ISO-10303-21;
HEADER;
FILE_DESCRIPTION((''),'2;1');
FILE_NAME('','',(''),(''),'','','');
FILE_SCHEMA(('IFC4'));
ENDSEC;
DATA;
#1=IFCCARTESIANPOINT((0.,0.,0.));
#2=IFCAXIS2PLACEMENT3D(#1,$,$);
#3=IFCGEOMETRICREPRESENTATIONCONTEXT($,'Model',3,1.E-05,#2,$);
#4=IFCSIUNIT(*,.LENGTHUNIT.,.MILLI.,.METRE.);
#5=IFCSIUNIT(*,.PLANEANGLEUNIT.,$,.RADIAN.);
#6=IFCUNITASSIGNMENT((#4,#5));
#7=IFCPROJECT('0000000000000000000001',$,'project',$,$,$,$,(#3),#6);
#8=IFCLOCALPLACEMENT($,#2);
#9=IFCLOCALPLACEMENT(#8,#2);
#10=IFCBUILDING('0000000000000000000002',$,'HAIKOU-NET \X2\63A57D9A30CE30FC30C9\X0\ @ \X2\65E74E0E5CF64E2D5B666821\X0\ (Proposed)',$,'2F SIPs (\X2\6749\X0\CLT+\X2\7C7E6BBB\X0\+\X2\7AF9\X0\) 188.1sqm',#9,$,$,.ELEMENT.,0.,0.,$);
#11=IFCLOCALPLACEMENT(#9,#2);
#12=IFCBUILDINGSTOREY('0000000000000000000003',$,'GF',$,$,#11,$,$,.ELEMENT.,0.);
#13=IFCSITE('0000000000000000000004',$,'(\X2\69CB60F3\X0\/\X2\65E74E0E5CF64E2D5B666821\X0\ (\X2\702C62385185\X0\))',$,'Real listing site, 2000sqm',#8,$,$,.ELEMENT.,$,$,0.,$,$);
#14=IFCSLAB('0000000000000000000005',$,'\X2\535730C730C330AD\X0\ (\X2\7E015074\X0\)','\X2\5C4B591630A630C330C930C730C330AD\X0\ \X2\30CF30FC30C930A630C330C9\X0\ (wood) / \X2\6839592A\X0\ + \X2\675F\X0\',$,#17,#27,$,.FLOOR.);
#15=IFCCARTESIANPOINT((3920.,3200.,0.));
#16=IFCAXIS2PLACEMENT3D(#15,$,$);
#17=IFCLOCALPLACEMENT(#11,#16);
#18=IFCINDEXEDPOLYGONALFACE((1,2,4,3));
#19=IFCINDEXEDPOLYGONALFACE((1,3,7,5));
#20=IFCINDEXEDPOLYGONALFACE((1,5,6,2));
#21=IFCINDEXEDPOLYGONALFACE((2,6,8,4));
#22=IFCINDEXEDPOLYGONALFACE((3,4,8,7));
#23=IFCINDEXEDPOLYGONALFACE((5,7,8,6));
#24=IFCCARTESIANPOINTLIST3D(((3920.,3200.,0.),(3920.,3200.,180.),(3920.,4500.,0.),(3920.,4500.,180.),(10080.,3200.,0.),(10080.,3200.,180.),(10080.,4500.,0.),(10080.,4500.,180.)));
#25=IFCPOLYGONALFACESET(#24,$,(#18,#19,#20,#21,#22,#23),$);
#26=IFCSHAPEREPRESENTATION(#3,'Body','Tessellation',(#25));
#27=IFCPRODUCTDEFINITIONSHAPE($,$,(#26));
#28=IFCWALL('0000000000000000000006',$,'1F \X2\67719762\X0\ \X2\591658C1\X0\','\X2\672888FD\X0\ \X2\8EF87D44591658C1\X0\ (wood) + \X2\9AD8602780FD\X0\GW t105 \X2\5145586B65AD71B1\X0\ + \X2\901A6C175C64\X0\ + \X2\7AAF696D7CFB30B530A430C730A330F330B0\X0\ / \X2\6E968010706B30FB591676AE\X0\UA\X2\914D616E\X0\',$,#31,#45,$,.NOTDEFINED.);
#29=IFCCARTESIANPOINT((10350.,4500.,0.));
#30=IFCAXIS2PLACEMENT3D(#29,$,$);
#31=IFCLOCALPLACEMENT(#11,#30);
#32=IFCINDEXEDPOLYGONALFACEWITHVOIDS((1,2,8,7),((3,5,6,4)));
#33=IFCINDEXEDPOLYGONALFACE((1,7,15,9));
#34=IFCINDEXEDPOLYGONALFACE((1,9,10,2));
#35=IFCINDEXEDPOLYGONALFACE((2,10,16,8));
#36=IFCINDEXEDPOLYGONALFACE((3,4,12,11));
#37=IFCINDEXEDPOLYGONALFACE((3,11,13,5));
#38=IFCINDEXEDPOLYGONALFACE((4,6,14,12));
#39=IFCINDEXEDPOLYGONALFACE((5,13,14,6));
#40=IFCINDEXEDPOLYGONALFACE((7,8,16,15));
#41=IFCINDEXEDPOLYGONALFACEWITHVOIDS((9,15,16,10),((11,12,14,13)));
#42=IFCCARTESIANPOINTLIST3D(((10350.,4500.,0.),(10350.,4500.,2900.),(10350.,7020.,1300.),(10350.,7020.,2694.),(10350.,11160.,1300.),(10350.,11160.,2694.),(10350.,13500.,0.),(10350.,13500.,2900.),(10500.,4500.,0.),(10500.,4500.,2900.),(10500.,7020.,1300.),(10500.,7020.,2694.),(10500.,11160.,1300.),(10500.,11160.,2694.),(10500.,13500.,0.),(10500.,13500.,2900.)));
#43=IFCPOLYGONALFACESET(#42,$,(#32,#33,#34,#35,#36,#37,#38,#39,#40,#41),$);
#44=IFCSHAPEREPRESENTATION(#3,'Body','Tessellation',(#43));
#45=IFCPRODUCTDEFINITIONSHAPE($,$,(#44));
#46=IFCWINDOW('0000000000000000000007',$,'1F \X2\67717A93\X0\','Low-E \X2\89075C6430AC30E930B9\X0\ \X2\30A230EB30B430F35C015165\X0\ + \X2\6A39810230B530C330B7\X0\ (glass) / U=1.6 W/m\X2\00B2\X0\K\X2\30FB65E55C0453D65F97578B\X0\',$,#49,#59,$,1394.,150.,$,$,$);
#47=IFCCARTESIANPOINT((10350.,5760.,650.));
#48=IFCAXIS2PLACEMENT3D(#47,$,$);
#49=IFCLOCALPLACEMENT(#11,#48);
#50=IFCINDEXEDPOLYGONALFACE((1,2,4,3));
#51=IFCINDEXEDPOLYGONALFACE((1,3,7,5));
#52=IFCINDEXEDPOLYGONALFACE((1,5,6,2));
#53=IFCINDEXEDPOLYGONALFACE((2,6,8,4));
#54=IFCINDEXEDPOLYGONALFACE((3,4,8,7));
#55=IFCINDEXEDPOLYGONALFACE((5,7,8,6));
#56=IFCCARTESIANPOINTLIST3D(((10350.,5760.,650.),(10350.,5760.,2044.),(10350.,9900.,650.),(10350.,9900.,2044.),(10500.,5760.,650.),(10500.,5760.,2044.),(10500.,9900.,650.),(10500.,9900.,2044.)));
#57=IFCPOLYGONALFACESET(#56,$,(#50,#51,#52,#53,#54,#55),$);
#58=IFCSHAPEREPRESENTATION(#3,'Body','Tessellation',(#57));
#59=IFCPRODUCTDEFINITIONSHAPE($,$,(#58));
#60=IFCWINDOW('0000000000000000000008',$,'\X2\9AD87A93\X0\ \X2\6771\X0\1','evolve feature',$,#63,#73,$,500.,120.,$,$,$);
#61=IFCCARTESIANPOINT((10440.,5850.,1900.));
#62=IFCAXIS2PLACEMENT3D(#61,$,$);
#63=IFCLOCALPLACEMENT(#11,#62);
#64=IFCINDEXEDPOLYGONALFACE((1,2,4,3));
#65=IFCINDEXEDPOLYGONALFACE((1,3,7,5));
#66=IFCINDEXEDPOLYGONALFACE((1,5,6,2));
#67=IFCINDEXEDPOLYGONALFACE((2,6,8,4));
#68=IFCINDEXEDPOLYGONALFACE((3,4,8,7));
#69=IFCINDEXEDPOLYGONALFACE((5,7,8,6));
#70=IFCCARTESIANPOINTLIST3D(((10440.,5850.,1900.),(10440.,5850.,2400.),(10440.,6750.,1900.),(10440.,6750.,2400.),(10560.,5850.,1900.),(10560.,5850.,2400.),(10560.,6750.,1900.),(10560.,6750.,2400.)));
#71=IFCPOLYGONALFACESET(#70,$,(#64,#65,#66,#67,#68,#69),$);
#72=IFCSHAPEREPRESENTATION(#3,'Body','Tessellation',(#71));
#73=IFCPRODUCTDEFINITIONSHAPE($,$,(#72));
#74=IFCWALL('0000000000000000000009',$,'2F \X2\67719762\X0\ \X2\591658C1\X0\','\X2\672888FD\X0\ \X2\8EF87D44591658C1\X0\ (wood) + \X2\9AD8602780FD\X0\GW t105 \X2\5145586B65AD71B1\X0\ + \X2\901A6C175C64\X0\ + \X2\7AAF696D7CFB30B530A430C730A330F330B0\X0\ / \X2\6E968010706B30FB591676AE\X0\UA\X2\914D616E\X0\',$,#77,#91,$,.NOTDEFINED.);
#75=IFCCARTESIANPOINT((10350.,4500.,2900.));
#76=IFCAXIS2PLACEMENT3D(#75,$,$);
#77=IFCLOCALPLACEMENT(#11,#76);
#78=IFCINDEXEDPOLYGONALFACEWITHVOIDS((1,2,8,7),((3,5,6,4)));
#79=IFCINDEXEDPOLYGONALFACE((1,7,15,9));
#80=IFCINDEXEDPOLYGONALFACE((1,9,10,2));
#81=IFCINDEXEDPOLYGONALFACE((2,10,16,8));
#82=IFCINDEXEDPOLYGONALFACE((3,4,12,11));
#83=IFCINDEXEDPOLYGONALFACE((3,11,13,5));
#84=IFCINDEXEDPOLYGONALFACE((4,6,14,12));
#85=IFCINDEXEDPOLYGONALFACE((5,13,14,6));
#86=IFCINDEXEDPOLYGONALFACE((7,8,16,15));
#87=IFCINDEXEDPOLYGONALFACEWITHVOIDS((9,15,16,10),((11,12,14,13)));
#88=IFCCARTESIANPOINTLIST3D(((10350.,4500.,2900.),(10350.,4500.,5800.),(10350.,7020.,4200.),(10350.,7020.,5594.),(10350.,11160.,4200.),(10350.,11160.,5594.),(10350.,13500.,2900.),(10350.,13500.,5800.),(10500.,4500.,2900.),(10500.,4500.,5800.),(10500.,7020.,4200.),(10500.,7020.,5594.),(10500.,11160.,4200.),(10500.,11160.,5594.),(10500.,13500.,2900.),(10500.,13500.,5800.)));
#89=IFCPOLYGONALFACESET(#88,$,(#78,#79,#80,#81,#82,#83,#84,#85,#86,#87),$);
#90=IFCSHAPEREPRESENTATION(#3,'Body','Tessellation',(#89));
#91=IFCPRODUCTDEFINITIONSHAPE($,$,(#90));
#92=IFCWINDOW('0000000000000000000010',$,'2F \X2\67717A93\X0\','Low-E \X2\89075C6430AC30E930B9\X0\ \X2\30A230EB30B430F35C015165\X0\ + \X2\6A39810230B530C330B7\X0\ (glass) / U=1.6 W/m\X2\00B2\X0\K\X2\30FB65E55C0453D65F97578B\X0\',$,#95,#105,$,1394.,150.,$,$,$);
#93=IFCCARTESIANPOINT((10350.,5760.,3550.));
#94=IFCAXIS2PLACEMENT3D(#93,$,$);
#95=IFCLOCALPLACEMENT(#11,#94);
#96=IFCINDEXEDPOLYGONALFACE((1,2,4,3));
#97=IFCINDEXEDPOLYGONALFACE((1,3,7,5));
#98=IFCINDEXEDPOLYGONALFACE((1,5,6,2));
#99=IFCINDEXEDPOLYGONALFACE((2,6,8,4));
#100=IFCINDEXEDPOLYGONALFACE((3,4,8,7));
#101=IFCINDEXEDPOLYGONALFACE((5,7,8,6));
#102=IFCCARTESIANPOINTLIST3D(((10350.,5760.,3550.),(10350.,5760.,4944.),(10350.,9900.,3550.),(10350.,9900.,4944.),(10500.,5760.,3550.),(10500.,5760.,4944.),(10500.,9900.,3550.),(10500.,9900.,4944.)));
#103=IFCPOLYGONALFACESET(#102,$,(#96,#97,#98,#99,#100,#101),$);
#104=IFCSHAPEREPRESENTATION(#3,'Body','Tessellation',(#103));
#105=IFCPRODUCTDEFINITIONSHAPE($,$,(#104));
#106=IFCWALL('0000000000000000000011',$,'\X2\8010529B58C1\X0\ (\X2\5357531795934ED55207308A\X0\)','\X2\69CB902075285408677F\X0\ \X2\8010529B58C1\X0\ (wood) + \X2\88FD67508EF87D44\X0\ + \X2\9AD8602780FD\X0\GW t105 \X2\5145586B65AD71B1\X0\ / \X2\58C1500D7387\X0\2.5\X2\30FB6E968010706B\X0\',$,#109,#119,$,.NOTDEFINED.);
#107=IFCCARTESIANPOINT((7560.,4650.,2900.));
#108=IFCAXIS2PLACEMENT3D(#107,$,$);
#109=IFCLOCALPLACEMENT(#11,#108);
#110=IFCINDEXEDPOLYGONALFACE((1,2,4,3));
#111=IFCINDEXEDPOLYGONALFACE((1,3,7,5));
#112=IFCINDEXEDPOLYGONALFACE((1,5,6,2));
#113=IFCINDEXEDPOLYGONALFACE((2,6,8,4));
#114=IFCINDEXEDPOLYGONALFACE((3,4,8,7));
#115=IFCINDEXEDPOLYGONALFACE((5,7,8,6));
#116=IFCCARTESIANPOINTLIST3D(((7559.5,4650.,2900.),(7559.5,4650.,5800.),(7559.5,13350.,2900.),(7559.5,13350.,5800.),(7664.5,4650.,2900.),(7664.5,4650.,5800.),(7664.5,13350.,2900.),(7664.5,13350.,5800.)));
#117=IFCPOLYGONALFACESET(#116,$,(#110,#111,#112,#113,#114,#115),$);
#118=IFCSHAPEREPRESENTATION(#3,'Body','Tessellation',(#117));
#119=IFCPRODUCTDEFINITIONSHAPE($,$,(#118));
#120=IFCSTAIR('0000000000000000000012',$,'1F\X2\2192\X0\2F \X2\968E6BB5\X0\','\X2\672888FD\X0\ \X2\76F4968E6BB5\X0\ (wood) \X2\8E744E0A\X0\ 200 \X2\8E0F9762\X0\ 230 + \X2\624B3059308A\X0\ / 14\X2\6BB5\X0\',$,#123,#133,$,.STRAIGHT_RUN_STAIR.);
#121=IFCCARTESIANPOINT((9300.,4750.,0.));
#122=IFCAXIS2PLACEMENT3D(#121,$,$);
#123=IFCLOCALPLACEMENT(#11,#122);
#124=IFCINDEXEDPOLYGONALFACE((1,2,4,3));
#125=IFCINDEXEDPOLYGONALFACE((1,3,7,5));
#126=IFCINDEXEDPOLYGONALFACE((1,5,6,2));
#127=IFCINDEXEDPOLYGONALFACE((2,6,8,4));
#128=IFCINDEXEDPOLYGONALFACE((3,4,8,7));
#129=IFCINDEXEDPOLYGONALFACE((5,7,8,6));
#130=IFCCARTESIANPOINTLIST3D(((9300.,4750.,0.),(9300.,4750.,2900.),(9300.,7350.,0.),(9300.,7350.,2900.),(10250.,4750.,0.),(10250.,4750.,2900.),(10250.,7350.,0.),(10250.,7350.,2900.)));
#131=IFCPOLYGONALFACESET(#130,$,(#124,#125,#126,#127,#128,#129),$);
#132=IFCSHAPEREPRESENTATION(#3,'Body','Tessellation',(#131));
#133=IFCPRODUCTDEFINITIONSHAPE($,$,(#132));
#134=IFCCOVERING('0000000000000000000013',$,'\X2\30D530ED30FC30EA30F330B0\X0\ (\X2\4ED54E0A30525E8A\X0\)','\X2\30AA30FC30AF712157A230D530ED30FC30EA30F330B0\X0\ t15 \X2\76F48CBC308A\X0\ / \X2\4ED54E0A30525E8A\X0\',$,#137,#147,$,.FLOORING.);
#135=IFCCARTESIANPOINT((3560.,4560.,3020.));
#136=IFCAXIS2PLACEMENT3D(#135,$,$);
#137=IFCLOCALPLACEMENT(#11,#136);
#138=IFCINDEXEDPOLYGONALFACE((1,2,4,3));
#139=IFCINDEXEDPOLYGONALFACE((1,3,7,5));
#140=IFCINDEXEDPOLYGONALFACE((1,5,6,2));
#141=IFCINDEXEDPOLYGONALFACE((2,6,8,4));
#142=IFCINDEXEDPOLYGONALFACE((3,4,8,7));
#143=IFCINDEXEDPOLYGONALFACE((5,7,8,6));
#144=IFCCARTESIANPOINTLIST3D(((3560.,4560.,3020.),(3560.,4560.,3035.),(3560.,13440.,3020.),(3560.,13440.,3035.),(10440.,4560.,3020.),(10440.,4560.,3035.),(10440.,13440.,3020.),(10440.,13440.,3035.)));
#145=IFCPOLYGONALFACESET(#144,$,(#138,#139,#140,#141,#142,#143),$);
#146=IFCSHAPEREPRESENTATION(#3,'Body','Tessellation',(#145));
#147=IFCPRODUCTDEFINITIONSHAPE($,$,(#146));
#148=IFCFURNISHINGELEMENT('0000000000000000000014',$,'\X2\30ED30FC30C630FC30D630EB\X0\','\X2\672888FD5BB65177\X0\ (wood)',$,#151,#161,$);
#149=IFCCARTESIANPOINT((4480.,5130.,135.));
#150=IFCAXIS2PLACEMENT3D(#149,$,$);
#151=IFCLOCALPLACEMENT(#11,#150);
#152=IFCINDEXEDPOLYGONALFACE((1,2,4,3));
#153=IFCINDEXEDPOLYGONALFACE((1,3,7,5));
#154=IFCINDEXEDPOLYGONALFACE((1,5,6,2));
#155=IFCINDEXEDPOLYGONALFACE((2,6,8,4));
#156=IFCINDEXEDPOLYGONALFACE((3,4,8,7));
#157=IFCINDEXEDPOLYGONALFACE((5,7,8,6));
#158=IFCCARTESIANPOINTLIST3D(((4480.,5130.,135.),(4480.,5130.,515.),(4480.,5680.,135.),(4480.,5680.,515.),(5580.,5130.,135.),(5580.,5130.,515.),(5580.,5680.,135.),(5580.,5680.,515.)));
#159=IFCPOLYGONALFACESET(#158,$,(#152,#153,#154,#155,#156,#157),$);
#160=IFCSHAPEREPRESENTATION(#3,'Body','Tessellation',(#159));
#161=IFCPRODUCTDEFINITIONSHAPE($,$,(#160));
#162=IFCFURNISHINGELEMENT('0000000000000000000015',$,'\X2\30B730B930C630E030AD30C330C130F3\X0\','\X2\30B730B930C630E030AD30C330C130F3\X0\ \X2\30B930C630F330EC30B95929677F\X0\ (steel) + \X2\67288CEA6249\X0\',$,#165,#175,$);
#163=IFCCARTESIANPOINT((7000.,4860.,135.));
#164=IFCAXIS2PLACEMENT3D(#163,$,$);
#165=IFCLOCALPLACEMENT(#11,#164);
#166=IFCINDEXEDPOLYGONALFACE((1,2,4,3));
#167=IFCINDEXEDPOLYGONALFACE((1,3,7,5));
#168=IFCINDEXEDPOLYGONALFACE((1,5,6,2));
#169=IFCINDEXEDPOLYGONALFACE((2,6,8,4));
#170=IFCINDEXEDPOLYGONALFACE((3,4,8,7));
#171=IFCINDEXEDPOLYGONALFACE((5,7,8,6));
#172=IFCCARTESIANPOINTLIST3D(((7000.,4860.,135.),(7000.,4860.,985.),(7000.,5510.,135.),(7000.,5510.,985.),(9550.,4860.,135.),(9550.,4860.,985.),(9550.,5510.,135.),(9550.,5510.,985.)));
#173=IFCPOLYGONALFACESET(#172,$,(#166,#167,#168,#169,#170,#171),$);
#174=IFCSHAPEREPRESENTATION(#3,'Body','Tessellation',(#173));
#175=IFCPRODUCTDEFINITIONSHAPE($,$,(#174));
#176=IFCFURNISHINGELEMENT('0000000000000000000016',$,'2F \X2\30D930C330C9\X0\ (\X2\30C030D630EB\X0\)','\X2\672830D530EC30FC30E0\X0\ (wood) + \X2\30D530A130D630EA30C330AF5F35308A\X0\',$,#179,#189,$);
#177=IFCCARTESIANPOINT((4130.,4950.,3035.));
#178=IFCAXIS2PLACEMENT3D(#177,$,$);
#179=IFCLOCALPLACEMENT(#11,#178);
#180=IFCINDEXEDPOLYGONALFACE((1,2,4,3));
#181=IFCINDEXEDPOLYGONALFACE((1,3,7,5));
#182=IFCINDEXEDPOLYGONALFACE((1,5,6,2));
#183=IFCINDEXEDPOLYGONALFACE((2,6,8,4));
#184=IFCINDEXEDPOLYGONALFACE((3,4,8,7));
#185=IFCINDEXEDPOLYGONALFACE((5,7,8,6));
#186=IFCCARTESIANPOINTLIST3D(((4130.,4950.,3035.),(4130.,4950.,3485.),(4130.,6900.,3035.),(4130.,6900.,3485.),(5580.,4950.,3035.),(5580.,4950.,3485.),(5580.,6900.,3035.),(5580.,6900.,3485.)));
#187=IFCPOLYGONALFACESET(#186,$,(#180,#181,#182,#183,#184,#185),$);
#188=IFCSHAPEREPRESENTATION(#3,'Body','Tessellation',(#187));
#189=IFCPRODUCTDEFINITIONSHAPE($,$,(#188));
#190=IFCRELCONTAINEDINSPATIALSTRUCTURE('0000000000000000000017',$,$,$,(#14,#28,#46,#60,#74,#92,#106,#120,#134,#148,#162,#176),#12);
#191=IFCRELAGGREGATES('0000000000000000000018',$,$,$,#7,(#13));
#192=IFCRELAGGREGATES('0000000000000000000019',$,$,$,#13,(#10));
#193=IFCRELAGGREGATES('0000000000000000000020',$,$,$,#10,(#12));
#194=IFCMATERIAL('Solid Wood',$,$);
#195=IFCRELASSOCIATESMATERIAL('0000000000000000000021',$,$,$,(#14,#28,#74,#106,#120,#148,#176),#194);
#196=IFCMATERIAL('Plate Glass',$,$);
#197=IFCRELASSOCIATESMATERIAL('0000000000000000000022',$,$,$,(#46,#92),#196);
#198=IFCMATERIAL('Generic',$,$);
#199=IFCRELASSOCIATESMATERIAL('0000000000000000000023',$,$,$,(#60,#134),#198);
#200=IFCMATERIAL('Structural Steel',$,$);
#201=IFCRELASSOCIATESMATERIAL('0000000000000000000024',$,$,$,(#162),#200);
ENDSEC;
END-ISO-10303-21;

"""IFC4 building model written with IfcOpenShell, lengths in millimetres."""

from ifc_helpers import new_model, si_unit, frame, frame_2d, origin, place, context, project, spatial, rectangle, extrude, material, element, fill, save


model = new_model("IFC4")

# Units and contexts
model_context = context("Model", 3, precision=1e-05, world=origin())
ifc_project = project(units=[si_unit("LENGTHUNIT", "METRE", prefix="MILLI"), si_unit("PLANEANGLEUNIT", "RADIAN")], contexts=[model_context])

# Site, building, storey
site_placement = place(None, origin())
site = spatial("IfcSite", under=ifc_project, at=site_placement, Name="(構想/旧与島中学校 (瀬戸内))", ObjectType="Real listing site, 2000sqm", CompositionType="ELEMENT", RefElevation=0.0)
building_placement = place(site_placement, origin())
building = spatial("IfcBuilding", under=site, at=building_placement, Name="HAIKOU-NET 接続ノード @ 旧与島中学校 (Proposed)", ObjectType="2F SIPs (杉CLT+籾殻+竹) 188.1sqm", CompositionType="ELEMENT", ElevationOfRefHeight=0.0, ElevationOfTerrain=0.0)
storey_placement = place(building_placement, origin())
storey = spatial("IfcBuildingStorey", under=building, at=storey_placement, Name="GF", CompositionType="ELEMENT", Elevation=0.0)

# Slab
ifc_material_1 = material(Name="Solid Wood")
slab_placement = place(storey_placement, frame((3920.0, 3200.0, 0.0)))
element("IfcSlab", 1, at=slab_placement, inside=storey, material=ifc_material_1, Name="南デッキ (縁側)", Description="屋外ウッドデッキ ハードウッド (wood) / 根太 + 束", PredefinedType="FLOOR", context=model_context, shape_type="SweptSolid", body=[
    extrude(rectangle(XDim=6160.0, YDim=1300.0, at=frame_2d((3080.0, 650.0))), frame((3920.0, 3200.0, 0.0)), (0.0, 0.0, 1.0), 180.0),
])

# Wall, openings, windows
wall_1_placement = place(storey_placement, frame((10350.0, 4500.0, 0.0)))
wall_1 = element("IfcWall", 2, at=wall_1_placement, inside=storey, material=ifc_material_1, Name="1F 東面 外壁", Description="木製 軸組外壁 (wood) + 高性能GW t105 充填断熱 + 通気層 + 窯業系サイディング / 準耐火・外皮UA配慮", PredefinedType="NOTDEFINED", context=model_context, shape_type="SweptSolid", body=[
    extrude(rectangle(XDim=150.0, YDim=9000.0, at=frame_2d((75.0, 4500.0))), frame((10350.0, 4500.0, 0.0)), (0.0, 0.0, 1.0), 2900.0),
])
opening_1_placement = place(storey_placement, frame((10350.0, 5760.0, 650.0)))
opening_1 = element("IfcOpeningElement", 3, at=opening_1_placement, cuts=wall_1, PredefinedType="NOTDEFINED", context=model_context, shape_type="SweptSolid", body=[
    extrude(rectangle(XDim=150.0, YDim=4140.0, at=frame_2d((75.0, 2070.0))), frame((10350.0, 5760.0, 650.0)), (0.0, 0.0, 1.0), 1394.0),
])
opening_2_placement = place(storey_placement, frame((10440.0, 5850.0, 1900.0)))
opening_2 = element("IfcOpeningElement", 4, at=opening_2_placement, cuts=wall_1, PredefinedType="NOTDEFINED", context=model_context, shape_type="SweptSolid", body=[
    extrude(rectangle(XDim=120.0, YDim=900.0, at=frame_2d((60.0, 450.0))), frame((10440.0, 5850.0, 1900.0)), (0.0, 0.0, 1.0), 500.0),
])
ifc_material_2 = material(Name="Plate Glass")
window_1_placement = place(storey_placement, frame((10350.0, 5760.0, 650.0)))
window_1 = element("IfcWindow", 5, at=window_1_placement, inside=storey, material=ifc_material_2, Name="1F 東窓", Description="Low-E 複層ガラス アルゴン封入 + 樹脂サッシ (glass) / U=1.6 W/m²K・日射取得型", OverallHeight=1394.0, OverallWidth=150.0, context=model_context, shape_type="SweptSolid", body=[
    extrude(rectangle(XDim=150.0, YDim=4140.0, at=frame_2d((75.0, 2070.0))), frame((10350.0, 5760.0, 650.0)), (0.0, 0.0, 1.0), 1394.0),
])
fill(opening_1, window_1)
ifc_material_3 = material(Name="Generic")
window_2_placement = place(storey_placement, frame((10440.0, 5850.0, 1900.0)))
window_2 = element("IfcWindow", 6, at=window_2_placement, inside=storey, material=ifc_material_3, Name="高窓 東1", Description="evolve feature", OverallHeight=500.0, OverallWidth=120.0, context=model_context, shape_type="SweptSolid", body=[
    extrude(rectangle(XDim=120.0, YDim=900.0, at=frame_2d((60.0, 450.0))), frame((10440.0, 5850.0, 1900.0)), (0.0, 0.0, 1.0), 500.0),
])
fill(opening_2, window_2)

# Wall, opening, window
wall_2_placement = place(storey_placement, frame((10350.0, 4500.0, 2900.0)))
wall_2 = element("IfcWall", 7, at=wall_2_placement, inside=storey, material=ifc_material_1, Name="2F 東面 外壁", Description="木製 軸組外壁 (wood) + 高性能GW t105 充填断熱 + 通気層 + 窯業系サイディング / 準耐火・外皮UA配慮", PredefinedType="NOTDEFINED", context=model_context, shape_type="SweptSolid", body=[
    extrude(rectangle(XDim=150.0, YDim=9000.0, at=frame_2d((75.0, 4500.0))), frame((10350.0, 4500.0, 2900.0)), (0.0, 0.0, 1.0), 2900.0),
])
opening_3_placement = place(storey_placement, frame((10350.0, 5760.0, 3550.0)))
opening_3 = element("IfcOpeningElement", 8, at=opening_3_placement, cuts=wall_2, PredefinedType="NOTDEFINED", context=model_context, shape_type="SweptSolid", body=[
    extrude(rectangle(XDim=150.0, YDim=4140.0, at=frame_2d((75.0, 2070.0))), frame((10350.0, 5760.0, 3550.0)), (0.0, 0.0, 1.0), 1394.0),
])
window_3_placement = place(storey_placement, frame((10350.0, 5760.0, 3550.0)))
window_3 = element("IfcWindow", 9, at=window_3_placement, inside=storey, material=ifc_material_2, Name="2F 東窓", Description="Low-E 複層ガラス アルゴン封入 + 樹脂サッシ (glass) / U=1.6 W/m²K・日射取得型", OverallHeight=1394.0, OverallWidth=150.0, context=model_context, shape_type="SweptSolid", body=[
    extrude(rectangle(XDim=150.0, YDim=4140.0, at=frame_2d((75.0, 2070.0))), frame((10350.0, 5760.0, 3550.0)), (0.0, 0.0, 1.0), 1394.0),
])
fill(opening_3, window_3)

# Wall
wall_3_placement = place(storey_placement, frame((7560.0, 4650.0, 2900.0)))
element("IfcWall", 10, at=wall_3_placement, inside=storey, material=ifc_material_1, Name="耐力壁 (南北間仕切り)", Description="構造用合板 耐力壁 (wood) + 製材軸組 + 高性能GW t105 充填断熱 / 壁倍率2.5・準耐火", PredefinedType="NOTDEFINED", context=model_context, shape_type="SweptSolid", body=[
    extrude(rectangle(XDim=105.0, YDim=8700.0, at=frame_2d((52.0, 4350.0))), frame((7560.0, 4650.0, 2900.0)), (0.0, 0.0, 1.0), 2900.0),
])

# Stair
stair_placement = place(storey_placement, frame((9300.0, 4750.0, 0.0)))
element("IfcStair", 11, at=stair_placement, inside=storey, material=ifc_material_1, Name="1F→2F 階段", Description="木製 直階段 (wood) 蹴上 200 踏面 230 + 手すり / 14段", PredefinedType="STRAIGHT_RUN_STAIR", context=model_context, shape_type="SweptSolid", body=[
    extrude(rectangle(XDim=950.0, YDim=2600.0, at=frame_2d((475.0, 1300.0))), frame((9300.0, 4750.0, 0.0)), (0.0, 0.0, 1.0), 2900.0),
])

# Covering
covering_placement = place(storey_placement, frame((3560.0, 4560.0, 3020.0)))
element("IfcCovering", 12, at=covering_placement, inside=storey, material=ifc_material_3, Name="フローリング (仕上げ床)", Description="オーク無垢フローリング t15 直貼り / 仕上げ床", PredefinedType="FLOORING", context=model_context, shape_type="SweptSolid", body=[
    extrude(rectangle(XDim=6880.0, YDim=8880.0, at=frame_2d((3440.0, 4440.0))), frame((3560.0, 4560.0, 3020.0)), (0.0, 0.0, 1.0), 15.0),
])

# Furnishing elements
furnishing_1_placement = place(storey_placement, frame((4480.0, 5130.0, 135.0)))
element("IfcFurnishingElement", 13, at=furnishing_1_placement, inside=storey, material=ifc_material_1, Name="ローテーブル", Description="木製家具 (wood)", context=model_context, shape_type="SweptSolid", body=[
    extrude(rectangle(XDim=1100.0, YDim=550.0, at=frame_2d((550.0, 275.0))), frame((4480.0, 5130.0, 135.0)), (0.0, 0.0, 1.0), 380.0),
])
ifc_material_4 = material(Name="Structural Steel")
furnishing_2_placement = place(storey_placement, frame((7000.0, 4860.0, 135.0)))
element("IfcFurnishingElement", 14, at=furnishing_2_placement, inside=storey, material=ifc_material_4, Name="システムキッチン", Description="システムキッチン ステンレス天板 (steel) + 木質扉", context=model_context, shape_type="SweptSolid", body=[
    extrude(rectangle(XDim=2550.0, YDim=650.0, at=frame_2d((1275.0, 325.0))), frame((7000.0, 4860.0, 135.0)), (0.0, 0.0, 1.0), 850.0),
])
furnishing_3_placement = place(storey_placement, frame((4130.0, 4950.0, 3035.0)))
element("IfcFurnishingElement", 15, at=furnishing_3_placement, inside=storey, material=ifc_material_1, Name="2F ベッド (ダブル)", Description="木フレーム (wood) + ファブリック張り", context=model_context, shape_type="SweptSolid", body=[
    extrude(rectangle(XDim=1450.0, YDim=1950.0, at=frame_2d((725.0, 975.0))), frame((4130.0, 4950.0, 3035.0)), (0.0, 0.0, 1.0), 450.0),
])

save(model, "model.ifc")
